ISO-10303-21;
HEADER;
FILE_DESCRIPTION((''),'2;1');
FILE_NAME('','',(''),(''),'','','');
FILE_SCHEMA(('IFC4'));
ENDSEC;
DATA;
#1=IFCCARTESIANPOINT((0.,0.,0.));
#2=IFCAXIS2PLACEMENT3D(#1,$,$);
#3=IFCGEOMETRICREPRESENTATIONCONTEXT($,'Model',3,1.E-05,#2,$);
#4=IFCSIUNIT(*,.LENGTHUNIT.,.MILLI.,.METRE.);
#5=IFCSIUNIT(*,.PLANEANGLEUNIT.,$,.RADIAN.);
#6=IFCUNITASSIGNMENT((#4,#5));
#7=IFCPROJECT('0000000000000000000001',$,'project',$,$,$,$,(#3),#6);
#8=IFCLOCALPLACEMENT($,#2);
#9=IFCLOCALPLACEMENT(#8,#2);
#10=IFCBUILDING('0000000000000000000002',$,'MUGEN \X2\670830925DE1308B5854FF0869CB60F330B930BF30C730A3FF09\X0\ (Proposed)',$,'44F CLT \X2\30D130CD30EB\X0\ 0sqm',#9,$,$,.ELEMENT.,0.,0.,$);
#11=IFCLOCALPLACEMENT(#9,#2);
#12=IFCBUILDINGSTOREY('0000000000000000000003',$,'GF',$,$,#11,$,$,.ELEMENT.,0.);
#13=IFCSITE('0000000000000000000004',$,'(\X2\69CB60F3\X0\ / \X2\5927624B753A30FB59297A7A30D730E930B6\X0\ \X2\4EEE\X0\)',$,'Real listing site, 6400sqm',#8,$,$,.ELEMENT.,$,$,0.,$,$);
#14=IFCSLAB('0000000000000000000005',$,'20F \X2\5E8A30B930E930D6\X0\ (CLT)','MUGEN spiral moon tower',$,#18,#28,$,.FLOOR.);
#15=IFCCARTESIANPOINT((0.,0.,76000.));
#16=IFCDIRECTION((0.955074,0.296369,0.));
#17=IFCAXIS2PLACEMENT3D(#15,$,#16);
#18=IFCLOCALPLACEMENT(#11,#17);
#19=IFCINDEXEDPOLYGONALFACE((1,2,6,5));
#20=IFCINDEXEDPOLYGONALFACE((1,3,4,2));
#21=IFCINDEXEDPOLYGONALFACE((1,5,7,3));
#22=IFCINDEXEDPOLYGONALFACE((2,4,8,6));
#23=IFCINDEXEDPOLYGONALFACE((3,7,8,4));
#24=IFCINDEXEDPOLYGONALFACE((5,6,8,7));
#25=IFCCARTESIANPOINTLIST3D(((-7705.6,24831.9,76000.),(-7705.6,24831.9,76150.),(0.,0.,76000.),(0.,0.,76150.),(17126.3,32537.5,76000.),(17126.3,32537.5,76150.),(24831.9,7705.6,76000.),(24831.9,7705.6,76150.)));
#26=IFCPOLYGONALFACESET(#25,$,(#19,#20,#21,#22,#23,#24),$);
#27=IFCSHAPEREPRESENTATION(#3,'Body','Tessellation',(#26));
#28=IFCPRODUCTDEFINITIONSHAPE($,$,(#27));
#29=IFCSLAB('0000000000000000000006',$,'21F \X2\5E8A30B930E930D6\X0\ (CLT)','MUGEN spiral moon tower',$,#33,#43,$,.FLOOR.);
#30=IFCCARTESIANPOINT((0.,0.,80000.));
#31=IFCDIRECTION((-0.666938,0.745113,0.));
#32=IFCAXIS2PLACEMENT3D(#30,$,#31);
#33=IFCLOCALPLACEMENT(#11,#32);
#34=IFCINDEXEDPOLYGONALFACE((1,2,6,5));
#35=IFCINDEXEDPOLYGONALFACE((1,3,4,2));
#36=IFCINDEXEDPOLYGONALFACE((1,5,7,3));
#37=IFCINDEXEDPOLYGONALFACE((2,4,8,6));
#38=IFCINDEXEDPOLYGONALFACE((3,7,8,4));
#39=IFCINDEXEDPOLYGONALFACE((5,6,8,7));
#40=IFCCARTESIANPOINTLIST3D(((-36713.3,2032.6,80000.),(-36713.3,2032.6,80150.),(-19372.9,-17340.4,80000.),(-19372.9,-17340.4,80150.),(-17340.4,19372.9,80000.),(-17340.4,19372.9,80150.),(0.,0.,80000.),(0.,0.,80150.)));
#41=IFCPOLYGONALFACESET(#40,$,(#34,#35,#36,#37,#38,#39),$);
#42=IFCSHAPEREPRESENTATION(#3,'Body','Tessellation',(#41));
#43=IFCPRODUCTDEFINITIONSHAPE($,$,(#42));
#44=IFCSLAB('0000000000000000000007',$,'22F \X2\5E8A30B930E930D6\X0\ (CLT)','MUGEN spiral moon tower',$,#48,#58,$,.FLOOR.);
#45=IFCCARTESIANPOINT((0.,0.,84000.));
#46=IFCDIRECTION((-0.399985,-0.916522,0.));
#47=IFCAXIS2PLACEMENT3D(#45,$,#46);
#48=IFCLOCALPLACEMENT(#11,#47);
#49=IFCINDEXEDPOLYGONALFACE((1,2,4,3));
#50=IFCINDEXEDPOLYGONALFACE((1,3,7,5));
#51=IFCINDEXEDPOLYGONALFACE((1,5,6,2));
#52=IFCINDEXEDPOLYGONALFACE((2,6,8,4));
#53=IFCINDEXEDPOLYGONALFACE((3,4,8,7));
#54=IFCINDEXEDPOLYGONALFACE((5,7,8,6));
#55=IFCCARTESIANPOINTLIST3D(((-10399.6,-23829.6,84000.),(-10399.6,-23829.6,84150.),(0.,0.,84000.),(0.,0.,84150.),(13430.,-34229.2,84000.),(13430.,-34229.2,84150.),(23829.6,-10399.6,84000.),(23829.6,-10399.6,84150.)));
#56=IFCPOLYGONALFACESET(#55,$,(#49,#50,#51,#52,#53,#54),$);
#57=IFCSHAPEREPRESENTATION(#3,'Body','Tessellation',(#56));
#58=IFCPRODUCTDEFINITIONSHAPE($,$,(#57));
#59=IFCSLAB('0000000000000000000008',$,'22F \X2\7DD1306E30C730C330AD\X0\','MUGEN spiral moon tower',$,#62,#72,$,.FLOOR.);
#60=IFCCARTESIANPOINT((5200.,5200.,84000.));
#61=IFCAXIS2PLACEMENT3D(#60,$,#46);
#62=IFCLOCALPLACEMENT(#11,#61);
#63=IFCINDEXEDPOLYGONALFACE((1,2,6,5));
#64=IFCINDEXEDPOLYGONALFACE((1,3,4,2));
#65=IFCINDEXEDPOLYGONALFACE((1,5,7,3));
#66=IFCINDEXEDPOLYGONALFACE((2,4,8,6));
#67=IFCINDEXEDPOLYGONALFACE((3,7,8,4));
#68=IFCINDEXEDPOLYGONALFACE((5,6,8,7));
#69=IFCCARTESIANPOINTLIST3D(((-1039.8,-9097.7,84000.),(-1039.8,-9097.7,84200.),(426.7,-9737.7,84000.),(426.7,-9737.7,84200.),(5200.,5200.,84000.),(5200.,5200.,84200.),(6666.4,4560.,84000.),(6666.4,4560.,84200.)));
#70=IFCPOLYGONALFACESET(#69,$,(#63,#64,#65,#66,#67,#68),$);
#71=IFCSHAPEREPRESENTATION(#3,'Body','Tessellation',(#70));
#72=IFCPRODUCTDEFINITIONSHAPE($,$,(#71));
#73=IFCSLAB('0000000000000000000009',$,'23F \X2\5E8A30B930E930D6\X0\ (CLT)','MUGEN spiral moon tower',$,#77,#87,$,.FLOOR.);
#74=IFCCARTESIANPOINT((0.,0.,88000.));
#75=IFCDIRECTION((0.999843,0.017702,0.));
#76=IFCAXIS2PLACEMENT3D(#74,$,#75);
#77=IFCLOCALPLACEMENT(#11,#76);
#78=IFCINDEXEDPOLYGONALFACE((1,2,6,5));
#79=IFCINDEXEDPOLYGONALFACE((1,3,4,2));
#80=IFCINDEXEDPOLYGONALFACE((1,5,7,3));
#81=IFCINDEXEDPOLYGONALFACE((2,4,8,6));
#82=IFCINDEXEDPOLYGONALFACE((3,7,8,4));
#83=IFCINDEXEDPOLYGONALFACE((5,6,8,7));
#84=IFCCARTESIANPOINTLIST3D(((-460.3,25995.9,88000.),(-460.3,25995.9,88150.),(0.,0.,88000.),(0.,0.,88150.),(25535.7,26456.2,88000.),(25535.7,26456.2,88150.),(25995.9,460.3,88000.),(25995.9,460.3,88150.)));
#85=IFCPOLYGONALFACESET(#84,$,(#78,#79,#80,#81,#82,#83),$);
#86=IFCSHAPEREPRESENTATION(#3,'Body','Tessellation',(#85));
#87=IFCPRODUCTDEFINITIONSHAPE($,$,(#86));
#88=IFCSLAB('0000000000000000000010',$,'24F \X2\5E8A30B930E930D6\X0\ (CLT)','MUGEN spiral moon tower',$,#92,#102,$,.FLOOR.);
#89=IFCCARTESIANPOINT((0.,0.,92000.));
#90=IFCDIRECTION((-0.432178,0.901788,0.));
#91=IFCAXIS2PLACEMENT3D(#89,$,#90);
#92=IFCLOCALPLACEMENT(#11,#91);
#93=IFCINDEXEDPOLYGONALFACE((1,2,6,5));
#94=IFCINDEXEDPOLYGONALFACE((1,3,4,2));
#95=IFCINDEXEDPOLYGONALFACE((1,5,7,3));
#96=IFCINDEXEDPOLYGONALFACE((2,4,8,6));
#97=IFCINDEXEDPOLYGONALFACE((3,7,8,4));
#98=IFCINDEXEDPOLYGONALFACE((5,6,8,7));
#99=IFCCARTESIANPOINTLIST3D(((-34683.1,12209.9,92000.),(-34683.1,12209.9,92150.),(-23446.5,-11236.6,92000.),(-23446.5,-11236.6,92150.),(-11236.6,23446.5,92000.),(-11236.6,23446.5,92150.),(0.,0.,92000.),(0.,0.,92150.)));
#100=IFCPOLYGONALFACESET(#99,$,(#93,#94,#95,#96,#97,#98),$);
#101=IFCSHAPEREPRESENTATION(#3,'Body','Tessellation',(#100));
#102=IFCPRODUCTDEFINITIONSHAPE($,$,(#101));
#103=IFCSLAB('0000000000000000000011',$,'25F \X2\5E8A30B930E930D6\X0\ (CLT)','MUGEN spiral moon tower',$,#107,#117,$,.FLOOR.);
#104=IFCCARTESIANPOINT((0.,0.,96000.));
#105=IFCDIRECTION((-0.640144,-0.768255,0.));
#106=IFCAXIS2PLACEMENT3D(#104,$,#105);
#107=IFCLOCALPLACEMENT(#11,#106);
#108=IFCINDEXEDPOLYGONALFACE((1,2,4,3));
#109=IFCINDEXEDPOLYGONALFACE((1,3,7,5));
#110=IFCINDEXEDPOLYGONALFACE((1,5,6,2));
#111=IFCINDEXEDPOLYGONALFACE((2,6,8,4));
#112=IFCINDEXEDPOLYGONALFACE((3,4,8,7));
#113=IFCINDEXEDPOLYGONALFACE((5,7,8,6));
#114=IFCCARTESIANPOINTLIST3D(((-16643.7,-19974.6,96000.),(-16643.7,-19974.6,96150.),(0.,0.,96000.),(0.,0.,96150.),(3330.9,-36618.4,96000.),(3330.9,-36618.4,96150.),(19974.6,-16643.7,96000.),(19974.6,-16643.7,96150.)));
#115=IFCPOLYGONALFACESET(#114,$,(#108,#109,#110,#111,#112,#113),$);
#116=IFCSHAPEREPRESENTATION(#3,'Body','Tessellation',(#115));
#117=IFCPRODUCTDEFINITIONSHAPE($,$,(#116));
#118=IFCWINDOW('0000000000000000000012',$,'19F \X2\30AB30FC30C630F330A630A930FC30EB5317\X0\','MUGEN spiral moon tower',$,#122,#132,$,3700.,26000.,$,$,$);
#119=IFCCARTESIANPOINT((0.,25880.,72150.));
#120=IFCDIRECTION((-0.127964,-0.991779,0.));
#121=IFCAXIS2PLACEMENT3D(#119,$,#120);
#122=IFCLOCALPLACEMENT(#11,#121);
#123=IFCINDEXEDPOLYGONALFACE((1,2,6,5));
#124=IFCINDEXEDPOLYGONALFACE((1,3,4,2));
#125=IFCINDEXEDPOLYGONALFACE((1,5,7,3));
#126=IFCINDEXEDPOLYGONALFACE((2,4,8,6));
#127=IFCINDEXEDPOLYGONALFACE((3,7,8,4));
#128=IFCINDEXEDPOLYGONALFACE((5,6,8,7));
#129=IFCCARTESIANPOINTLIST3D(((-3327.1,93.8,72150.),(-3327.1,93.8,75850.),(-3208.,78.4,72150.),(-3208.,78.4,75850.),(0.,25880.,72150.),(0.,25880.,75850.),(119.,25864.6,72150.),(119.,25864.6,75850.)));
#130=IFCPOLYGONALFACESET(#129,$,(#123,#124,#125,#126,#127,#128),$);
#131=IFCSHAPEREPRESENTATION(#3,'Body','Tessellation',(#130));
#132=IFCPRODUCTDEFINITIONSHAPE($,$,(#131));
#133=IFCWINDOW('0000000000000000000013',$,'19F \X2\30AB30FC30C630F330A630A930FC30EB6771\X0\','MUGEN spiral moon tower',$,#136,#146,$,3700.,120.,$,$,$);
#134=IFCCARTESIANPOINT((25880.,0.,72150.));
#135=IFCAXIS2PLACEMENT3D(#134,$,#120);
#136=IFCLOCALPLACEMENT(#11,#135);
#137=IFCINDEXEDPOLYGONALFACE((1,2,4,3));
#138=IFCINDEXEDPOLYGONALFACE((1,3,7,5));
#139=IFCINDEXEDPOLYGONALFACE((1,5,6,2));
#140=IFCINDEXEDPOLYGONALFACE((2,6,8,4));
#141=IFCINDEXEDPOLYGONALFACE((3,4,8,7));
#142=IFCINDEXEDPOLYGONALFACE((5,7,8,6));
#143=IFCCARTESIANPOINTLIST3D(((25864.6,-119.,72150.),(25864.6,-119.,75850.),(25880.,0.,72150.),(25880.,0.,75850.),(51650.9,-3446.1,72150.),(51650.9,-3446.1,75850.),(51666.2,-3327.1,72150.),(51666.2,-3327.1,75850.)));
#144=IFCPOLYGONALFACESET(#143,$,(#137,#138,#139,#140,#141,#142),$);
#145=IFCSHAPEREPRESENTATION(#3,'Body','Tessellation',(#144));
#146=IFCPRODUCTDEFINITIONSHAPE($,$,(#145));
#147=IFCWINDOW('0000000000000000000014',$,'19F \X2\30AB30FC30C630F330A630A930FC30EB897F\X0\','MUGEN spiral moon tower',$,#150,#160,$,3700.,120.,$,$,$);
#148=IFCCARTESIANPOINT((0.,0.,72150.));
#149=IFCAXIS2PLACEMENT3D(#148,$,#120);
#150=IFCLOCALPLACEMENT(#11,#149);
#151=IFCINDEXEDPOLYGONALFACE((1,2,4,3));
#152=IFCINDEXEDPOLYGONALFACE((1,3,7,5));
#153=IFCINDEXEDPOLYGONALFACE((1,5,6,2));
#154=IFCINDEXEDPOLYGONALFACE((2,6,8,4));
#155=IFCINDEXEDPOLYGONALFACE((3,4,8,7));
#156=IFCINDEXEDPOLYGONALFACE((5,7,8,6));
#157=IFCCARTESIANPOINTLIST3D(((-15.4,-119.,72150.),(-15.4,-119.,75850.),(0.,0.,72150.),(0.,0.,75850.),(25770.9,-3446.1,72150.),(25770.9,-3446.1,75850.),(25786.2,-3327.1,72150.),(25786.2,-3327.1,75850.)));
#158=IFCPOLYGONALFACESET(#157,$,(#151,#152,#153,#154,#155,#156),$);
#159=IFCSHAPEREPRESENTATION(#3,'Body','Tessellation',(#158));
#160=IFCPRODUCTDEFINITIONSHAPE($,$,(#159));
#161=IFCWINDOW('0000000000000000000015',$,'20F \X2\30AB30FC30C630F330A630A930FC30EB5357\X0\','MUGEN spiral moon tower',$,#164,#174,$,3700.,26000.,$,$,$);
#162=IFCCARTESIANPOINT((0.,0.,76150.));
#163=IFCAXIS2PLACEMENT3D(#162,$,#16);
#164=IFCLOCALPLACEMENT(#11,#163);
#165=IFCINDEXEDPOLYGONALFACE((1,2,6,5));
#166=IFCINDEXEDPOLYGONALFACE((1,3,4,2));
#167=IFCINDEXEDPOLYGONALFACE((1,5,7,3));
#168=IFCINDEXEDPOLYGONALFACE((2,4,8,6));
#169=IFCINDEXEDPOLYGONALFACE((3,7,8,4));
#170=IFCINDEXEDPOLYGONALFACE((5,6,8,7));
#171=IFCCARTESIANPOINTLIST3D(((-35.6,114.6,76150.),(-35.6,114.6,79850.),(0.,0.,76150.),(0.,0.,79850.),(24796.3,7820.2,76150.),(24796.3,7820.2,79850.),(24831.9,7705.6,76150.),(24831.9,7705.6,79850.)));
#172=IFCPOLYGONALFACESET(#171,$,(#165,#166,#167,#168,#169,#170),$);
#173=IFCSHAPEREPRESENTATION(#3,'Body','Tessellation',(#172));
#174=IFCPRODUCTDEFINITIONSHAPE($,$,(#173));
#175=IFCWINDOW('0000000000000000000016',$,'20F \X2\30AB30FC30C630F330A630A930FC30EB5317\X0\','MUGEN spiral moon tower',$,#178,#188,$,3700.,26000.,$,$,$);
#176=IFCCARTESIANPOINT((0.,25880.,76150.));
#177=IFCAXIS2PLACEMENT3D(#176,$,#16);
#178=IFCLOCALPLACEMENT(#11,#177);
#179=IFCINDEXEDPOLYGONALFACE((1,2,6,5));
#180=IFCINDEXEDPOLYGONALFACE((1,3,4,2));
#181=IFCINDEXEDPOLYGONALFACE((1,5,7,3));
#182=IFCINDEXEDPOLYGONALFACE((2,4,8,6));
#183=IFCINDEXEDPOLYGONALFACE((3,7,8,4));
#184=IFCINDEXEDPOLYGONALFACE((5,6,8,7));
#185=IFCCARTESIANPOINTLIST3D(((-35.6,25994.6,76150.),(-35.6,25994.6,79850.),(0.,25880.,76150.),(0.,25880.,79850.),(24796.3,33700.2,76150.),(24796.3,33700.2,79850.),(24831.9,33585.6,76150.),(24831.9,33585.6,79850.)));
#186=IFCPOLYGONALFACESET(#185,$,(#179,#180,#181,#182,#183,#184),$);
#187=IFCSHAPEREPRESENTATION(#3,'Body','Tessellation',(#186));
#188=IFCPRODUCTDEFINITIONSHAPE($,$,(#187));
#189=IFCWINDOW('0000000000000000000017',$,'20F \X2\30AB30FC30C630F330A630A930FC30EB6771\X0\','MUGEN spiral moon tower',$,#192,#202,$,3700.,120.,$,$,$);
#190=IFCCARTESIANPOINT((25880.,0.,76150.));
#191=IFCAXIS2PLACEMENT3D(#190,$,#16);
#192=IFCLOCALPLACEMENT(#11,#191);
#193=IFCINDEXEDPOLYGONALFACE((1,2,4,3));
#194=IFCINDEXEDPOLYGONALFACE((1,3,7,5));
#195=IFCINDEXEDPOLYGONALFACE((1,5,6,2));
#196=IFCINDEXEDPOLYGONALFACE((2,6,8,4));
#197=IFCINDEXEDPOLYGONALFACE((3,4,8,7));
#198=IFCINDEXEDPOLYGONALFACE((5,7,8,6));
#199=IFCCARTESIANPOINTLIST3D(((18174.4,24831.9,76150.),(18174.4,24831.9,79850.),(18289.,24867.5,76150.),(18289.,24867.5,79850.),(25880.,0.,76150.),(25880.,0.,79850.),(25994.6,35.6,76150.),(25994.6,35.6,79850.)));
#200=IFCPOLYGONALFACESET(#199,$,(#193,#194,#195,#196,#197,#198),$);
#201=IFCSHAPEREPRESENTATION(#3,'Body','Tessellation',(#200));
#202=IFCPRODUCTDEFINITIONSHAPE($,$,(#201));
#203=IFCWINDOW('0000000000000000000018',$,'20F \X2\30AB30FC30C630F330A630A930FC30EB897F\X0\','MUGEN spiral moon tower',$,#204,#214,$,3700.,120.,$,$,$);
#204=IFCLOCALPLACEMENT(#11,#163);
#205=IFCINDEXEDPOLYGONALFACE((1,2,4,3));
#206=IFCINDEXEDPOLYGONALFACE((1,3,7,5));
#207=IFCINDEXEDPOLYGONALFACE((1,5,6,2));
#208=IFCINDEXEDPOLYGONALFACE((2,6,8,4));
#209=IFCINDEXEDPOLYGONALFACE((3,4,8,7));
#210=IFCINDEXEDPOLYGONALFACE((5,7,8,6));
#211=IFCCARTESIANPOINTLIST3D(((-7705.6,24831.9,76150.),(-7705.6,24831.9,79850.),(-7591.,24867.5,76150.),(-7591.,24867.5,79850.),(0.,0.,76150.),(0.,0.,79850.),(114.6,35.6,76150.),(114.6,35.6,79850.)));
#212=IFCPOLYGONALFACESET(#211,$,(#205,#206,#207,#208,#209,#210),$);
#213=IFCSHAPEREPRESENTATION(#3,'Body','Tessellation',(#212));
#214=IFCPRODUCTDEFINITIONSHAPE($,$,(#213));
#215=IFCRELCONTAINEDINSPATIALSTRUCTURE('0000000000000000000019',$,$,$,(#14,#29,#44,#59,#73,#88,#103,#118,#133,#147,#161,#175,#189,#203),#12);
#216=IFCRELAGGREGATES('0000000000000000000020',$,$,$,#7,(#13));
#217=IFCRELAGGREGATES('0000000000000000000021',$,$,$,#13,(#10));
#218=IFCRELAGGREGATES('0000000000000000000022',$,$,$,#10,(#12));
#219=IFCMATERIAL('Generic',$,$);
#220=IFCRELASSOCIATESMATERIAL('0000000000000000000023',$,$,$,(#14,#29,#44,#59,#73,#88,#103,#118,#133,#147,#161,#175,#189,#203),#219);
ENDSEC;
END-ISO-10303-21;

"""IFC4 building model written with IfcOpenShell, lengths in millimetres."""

from ifc_helpers import new_model, si_unit, frame, frame_2d, origin, place, context, project, spatial, rectangle, extrude, material, element, save


model = new_model("IFC4")

# Units and contexts
model_context = context("Model", 3, precision=1e-05, world=origin())
ifc_project = project(units=[si_unit("LENGTHUNIT", "METRE", prefix="MILLI"), si_unit("PLANEANGLEUNIT", "RADIAN")], contexts=[model_context])

# Site, building, storey
site_placement = place(None, origin())
site = spatial("IfcSite", under=ifc_project, at=site_placement, Name="(構想 / 大手町・天空プラザ 仮)", ObjectType="Real listing site, 6400sqm", CompositionType="ELEMENT", RefElevation=0.0)
building_placement = place(site_placement, origin())
building = spatial("IfcBuilding", under=site, at=building_placement, Name="MUGEN 月を巡る塔（構想スタディ） (Proposed)", ObjectType="44F CLT パネル 0sqm", CompositionType="ELEMENT", ElevationOfRefHeight=0.0, ElevationOfTerrain=0.0)
storey_placement = place(building_placement, origin())
storey = spatial("IfcBuildingStorey", under=building, at=storey_placement, Name="GF", CompositionType="ELEMENT", Elevation=0.0)

# Slabs
ifc_material = material(Name="Generic")
slab_1_placement = place(storey_placement, frame((0.0, 0.0, 76000.0), x_axis=(0.955074, 0.296369, 0.0)))
element("IfcSlab", 1, at=slab_1_placement, inside=storey, material=ifc_material, Name="20F 床スラブ (CLT)", Description="MUGEN spiral moon tower", PredefinedType="FLOOR", context=model_context, shape_type="SweptSolid", body=[
    extrude(rectangle(XDim=26000.0, YDim=26000.0, at=frame_2d((13000.0, 13000.0))), frame((0.0, 0.0, 76000.0), x_axis=(0.955074, 0.296369, 0.0)), (0.0, 0.0, 1.0), 150.0),
])
slab_2_placement = place(storey_placement, frame((0.0, 0.0, 80000.0), x_axis=(-0.666938, 0.745113, 0.0)))
element("IfcSlab", 2, at=slab_2_placement, inside=storey, material=ifc_material, Name="21F 床スラブ (CLT)", Description="MUGEN spiral moon tower", PredefinedType="FLOOR", context=model_context, shape_type="SweptSolid", body=[
    extrude(rectangle(XDim=26000.0, YDim=26000.0, at=frame_2d((13000.0, 13000.0))), frame((0.0, 0.0, 80000.0), x_axis=(-0.666938, 0.745113, 0.0)), (0.0, 0.0, 1.0), 150.0),
])
slab_3_placement = place(storey_placement, frame((0.0, 0.0, 84000.0), x_axis=(-0.399985, -0.916522, 0.0)))
element("IfcSlab", 3, at=slab_3_placement, inside=storey, material=ifc_material, Name="22F 床スラブ (CLT)", Description="MUGEN spiral moon tower", PredefinedType="FLOOR", context=model_context, shape_type="SweptSolid", body=[
    extrude(rectangle(XDim=26000.0, YDim=26000.0, at=frame_2d((13000.0, 13000.0))), frame((0.0, 0.0, 84000.0), x_axis=(-0.399985, -0.916522, 0.0)), (0.0, 0.0, 1.0), 150.0),
])
slab_4_placement = place(storey_placement, frame((5200.0, 5200.0, 84000.0), x_axis=(-0.399985, -0.916522, 0.0)))
element("IfcSlab", 4, at=slab_4_placement, inside=storey, material=ifc_material, Name="22F 緑のデッキ", Description="MUGEN spiral moon tower", PredefinedType="FLOOR", context=model_context, shape_type="SweptSolid", body=[
    extrude(rectangle(XDim=15600.0, YDim=1600.0, at=frame_2d((7800.0, 800.0))), frame((5200.0, 5200.0, 84000.0), x_axis=(-0.399985, -0.916522, 0.0)), (0.0, 0.0, 1.0), 200.0),
])
slab_5_placement = place(storey_placement, frame((0.0, 0.0, 88000.0), x_axis=(0.999843, 0.017702, 0.0)))
element("IfcSlab", 5, at=slab_5_placement, inside=storey, material=ifc_material, Name="23F 床スラブ (CLT)", Description="MUGEN spiral moon tower", PredefinedType="FLOOR", context=model_context, shape_type="SweptSolid", body=[
    extrude(rectangle(XDim=26000.0, YDim=26000.0, at=frame_2d((13000.0, 13000.0))), frame((0.0, 0.0, 88000.0), x_axis=(0.999843, 0.017702, 0.0)), (0.0, 0.0, 1.0), 150.0),
])
slab_6_placement = place(storey_placement, frame((0.0, 0.0, 92000.0), x_axis=(-0.432178, 0.901788, 0.0)))
element("IfcSlab", 6, at=slab_6_placement, inside=storey, material=ifc_material, Name="24F 床スラブ (CLT)", Description="MUGEN spiral moon tower", PredefinedType="FLOOR", context=model_context, shape_type="SweptSolid", body=[
    extrude(rectangle(XDim=26000.0, YDim=26000.0, at=frame_2d((13000.0, 13000.0))), frame((0.0, 0.0, 92000.0), x_axis=(-0.432178, 0.901788, 0.0)), (0.0, 0.0, 1.0), 150.0),
])
slab_7_placement = place(storey_placement, frame((0.0, 0.0, 96000.0), x_axis=(-0.640144, -0.768255, 0.0)))
element("IfcSlab", 7, at=slab_7_placement, inside=storey, material=ifc_material, Name="25F 床スラブ (CLT)", Description="MUGEN spiral moon tower", PredefinedType="FLOOR", context=model_context, shape_type="SweptSolid", body=[
    extrude(rectangle(XDim=26000.0, YDim=26000.0, at=frame_2d((13000.0, 13000.0))), frame((0.0, 0.0, 96000.0), x_axis=(-0.640144, -0.768255, 0.0)), (0.0, 0.0, 1.0), 150.0),
])

# Windows
window_1_placement = place(storey_placement, frame((0.0, 25880.0, 72150.0), x_axis=(-0.127964, -0.991779, 0.0)))
element("IfcWindow", 8, at=window_1_placement, inside=storey, material=ifc_material, Name="19F カーテンウォール北", Description="MUGEN spiral moon tower", OverallHeight=3700.0, OverallWidth=26000.0, context=model_context, shape_type="SweptSolid", body=[
    extrude(rectangle(XDim=26000.0, YDim=120.0, at=frame_2d((13000.0, 60.0))), frame((0.0, 25880.0, 72150.0), x_axis=(-0.127964, -0.991779, 0.0)), (0.0, 0.0, 1.0), 3700.0),
])
window_2_placement = place(storey_placement, frame((25880.0, 0.0, 72150.0), x_axis=(-0.127964, -0.991779, 0.0)))
element("IfcWindow", 9, at=window_2_placement, inside=storey, material=ifc_material, Name="19F カーテンウォール東", Description="MUGEN spiral moon tower", OverallHeight=3700.0, OverallWidth=120.0, context=model_context, shape_type="SweptSolid", body=[
    extrude(rectangle(XDim=120.0, YDim=26000.0, at=frame_2d((60.0, 13000.0))), frame((25880.0, 0.0, 72150.0), x_axis=(-0.127964, -0.991779, 0.0)), (0.0, 0.0, 1.0), 3700.0),
])
window_3_placement = place(storey_placement, frame((0.0, 0.0, 72150.0), x_axis=(-0.127964, -0.991779, 0.0)))
element("IfcWindow", 10, at=window_3_placement, inside=storey, material=ifc_material, Name="19F カーテンウォール西", Description="MUGEN spiral moon tower", OverallHeight=3700.0, OverallWidth=120.0, context=model_context, shape_type="SweptSolid", body=[
    extrude(rectangle(XDim=120.0, YDim=26000.0, at=frame_2d((60.0, 13000.0))), frame((0.0, 0.0, 72150.0), x_axis=(-0.127964, -0.991779, 0.0)), (0.0, 0.0, 1.0), 3700.0),
])
window_4_placement = place(storey_placement, frame((0.0, 0.0, 76150.0), x_axis=(0.955074, 0.296369, 0.0)))
element("IfcWindow", 11, at=window_4_placement, inside=storey, material=ifc_material, Name="20F カーテンウォール南", Description="MUGEN spiral moon tower", OverallHeight=3700.0, OverallWidth=26000.0, context=model_context, shape_type="SweptSolid", body=[
    extrude(rectangle(XDim=26000.0, YDim=120.0, at=frame_2d((13000.0, 60.0))), frame((0.0, 0.0, 76150.0), x_axis=(0.955074, 0.296369, 0.0)), (0.0, 0.0, 1.0), 3700.0),
])
window_5_placement = place(storey_placement, frame((0.0, 25880.0, 76150.0), x_axis=(0.955074, 0.296369, 0.0)))
element("IfcWindow", 12, at=window_5_placement, inside=storey, material=ifc_material, Name="20F カーテンウォール北", Description="MUGEN spiral moon tower", OverallHeight=3700.0, OverallWidth=26000.0, context=model_context, shape_type="SweptSolid", body=[
    extrude(rectangle(XDim=26000.0, YDim=120.0, at=frame_2d((13000.0, 60.0))), frame((0.0, 25880.0, 76150.0), x_axis=(0.955074, 0.296369, 0.0)), (0.0, 0.0, 1.0), 3700.0),
])
window_6_placement = place(storey_placement, frame((25880.0, 0.0, 76150.0), x_axis=(0.955074, 0.296369, 0.0)))
element("IfcWindow", 13, at=window_6_placement, inside=storey, material=ifc_material, Name="20F カーテンウォール東", Description="MUGEN spiral moon tower", OverallHeight=3700.0, OverallWidth=120.0, context=model_context, shape_type="SweptSolid", body=[
    extrude(rectangle(XDim=120.0, YDim=26000.0, at=frame_2d((60.0, 13000.0))), frame((25880.0, 0.0, 76150.0), x_axis=(0.955074, 0.296369, 0.0)), (0.0, 0.0, 1.0), 3700.0),
])
window_7_placement = place(storey_placement, frame((0.0, 0.0, 76150.0), x_axis=(0.955074, 0.296369, 0.0)))
element("IfcWindow", 14, at=window_7_placement, inside=storey, material=ifc_material, Name="20F カーテンウォール西", Description="MUGEN spiral moon tower", OverallHeight=3700.0, OverallWidth=120.0, context=model_context, shape_type="SweptSolid", body=[
    extrude(rectangle(XDim=120.0, YDim=26000.0, at=frame_2d((60.0, 13000.0))), frame((0.0, 0.0, 76150.0), x_axis=(0.955074, 0.296369, 0.0)), (0.0, 0.0, 1.0), 3700.0),
])

save(model, "model.ifc")
